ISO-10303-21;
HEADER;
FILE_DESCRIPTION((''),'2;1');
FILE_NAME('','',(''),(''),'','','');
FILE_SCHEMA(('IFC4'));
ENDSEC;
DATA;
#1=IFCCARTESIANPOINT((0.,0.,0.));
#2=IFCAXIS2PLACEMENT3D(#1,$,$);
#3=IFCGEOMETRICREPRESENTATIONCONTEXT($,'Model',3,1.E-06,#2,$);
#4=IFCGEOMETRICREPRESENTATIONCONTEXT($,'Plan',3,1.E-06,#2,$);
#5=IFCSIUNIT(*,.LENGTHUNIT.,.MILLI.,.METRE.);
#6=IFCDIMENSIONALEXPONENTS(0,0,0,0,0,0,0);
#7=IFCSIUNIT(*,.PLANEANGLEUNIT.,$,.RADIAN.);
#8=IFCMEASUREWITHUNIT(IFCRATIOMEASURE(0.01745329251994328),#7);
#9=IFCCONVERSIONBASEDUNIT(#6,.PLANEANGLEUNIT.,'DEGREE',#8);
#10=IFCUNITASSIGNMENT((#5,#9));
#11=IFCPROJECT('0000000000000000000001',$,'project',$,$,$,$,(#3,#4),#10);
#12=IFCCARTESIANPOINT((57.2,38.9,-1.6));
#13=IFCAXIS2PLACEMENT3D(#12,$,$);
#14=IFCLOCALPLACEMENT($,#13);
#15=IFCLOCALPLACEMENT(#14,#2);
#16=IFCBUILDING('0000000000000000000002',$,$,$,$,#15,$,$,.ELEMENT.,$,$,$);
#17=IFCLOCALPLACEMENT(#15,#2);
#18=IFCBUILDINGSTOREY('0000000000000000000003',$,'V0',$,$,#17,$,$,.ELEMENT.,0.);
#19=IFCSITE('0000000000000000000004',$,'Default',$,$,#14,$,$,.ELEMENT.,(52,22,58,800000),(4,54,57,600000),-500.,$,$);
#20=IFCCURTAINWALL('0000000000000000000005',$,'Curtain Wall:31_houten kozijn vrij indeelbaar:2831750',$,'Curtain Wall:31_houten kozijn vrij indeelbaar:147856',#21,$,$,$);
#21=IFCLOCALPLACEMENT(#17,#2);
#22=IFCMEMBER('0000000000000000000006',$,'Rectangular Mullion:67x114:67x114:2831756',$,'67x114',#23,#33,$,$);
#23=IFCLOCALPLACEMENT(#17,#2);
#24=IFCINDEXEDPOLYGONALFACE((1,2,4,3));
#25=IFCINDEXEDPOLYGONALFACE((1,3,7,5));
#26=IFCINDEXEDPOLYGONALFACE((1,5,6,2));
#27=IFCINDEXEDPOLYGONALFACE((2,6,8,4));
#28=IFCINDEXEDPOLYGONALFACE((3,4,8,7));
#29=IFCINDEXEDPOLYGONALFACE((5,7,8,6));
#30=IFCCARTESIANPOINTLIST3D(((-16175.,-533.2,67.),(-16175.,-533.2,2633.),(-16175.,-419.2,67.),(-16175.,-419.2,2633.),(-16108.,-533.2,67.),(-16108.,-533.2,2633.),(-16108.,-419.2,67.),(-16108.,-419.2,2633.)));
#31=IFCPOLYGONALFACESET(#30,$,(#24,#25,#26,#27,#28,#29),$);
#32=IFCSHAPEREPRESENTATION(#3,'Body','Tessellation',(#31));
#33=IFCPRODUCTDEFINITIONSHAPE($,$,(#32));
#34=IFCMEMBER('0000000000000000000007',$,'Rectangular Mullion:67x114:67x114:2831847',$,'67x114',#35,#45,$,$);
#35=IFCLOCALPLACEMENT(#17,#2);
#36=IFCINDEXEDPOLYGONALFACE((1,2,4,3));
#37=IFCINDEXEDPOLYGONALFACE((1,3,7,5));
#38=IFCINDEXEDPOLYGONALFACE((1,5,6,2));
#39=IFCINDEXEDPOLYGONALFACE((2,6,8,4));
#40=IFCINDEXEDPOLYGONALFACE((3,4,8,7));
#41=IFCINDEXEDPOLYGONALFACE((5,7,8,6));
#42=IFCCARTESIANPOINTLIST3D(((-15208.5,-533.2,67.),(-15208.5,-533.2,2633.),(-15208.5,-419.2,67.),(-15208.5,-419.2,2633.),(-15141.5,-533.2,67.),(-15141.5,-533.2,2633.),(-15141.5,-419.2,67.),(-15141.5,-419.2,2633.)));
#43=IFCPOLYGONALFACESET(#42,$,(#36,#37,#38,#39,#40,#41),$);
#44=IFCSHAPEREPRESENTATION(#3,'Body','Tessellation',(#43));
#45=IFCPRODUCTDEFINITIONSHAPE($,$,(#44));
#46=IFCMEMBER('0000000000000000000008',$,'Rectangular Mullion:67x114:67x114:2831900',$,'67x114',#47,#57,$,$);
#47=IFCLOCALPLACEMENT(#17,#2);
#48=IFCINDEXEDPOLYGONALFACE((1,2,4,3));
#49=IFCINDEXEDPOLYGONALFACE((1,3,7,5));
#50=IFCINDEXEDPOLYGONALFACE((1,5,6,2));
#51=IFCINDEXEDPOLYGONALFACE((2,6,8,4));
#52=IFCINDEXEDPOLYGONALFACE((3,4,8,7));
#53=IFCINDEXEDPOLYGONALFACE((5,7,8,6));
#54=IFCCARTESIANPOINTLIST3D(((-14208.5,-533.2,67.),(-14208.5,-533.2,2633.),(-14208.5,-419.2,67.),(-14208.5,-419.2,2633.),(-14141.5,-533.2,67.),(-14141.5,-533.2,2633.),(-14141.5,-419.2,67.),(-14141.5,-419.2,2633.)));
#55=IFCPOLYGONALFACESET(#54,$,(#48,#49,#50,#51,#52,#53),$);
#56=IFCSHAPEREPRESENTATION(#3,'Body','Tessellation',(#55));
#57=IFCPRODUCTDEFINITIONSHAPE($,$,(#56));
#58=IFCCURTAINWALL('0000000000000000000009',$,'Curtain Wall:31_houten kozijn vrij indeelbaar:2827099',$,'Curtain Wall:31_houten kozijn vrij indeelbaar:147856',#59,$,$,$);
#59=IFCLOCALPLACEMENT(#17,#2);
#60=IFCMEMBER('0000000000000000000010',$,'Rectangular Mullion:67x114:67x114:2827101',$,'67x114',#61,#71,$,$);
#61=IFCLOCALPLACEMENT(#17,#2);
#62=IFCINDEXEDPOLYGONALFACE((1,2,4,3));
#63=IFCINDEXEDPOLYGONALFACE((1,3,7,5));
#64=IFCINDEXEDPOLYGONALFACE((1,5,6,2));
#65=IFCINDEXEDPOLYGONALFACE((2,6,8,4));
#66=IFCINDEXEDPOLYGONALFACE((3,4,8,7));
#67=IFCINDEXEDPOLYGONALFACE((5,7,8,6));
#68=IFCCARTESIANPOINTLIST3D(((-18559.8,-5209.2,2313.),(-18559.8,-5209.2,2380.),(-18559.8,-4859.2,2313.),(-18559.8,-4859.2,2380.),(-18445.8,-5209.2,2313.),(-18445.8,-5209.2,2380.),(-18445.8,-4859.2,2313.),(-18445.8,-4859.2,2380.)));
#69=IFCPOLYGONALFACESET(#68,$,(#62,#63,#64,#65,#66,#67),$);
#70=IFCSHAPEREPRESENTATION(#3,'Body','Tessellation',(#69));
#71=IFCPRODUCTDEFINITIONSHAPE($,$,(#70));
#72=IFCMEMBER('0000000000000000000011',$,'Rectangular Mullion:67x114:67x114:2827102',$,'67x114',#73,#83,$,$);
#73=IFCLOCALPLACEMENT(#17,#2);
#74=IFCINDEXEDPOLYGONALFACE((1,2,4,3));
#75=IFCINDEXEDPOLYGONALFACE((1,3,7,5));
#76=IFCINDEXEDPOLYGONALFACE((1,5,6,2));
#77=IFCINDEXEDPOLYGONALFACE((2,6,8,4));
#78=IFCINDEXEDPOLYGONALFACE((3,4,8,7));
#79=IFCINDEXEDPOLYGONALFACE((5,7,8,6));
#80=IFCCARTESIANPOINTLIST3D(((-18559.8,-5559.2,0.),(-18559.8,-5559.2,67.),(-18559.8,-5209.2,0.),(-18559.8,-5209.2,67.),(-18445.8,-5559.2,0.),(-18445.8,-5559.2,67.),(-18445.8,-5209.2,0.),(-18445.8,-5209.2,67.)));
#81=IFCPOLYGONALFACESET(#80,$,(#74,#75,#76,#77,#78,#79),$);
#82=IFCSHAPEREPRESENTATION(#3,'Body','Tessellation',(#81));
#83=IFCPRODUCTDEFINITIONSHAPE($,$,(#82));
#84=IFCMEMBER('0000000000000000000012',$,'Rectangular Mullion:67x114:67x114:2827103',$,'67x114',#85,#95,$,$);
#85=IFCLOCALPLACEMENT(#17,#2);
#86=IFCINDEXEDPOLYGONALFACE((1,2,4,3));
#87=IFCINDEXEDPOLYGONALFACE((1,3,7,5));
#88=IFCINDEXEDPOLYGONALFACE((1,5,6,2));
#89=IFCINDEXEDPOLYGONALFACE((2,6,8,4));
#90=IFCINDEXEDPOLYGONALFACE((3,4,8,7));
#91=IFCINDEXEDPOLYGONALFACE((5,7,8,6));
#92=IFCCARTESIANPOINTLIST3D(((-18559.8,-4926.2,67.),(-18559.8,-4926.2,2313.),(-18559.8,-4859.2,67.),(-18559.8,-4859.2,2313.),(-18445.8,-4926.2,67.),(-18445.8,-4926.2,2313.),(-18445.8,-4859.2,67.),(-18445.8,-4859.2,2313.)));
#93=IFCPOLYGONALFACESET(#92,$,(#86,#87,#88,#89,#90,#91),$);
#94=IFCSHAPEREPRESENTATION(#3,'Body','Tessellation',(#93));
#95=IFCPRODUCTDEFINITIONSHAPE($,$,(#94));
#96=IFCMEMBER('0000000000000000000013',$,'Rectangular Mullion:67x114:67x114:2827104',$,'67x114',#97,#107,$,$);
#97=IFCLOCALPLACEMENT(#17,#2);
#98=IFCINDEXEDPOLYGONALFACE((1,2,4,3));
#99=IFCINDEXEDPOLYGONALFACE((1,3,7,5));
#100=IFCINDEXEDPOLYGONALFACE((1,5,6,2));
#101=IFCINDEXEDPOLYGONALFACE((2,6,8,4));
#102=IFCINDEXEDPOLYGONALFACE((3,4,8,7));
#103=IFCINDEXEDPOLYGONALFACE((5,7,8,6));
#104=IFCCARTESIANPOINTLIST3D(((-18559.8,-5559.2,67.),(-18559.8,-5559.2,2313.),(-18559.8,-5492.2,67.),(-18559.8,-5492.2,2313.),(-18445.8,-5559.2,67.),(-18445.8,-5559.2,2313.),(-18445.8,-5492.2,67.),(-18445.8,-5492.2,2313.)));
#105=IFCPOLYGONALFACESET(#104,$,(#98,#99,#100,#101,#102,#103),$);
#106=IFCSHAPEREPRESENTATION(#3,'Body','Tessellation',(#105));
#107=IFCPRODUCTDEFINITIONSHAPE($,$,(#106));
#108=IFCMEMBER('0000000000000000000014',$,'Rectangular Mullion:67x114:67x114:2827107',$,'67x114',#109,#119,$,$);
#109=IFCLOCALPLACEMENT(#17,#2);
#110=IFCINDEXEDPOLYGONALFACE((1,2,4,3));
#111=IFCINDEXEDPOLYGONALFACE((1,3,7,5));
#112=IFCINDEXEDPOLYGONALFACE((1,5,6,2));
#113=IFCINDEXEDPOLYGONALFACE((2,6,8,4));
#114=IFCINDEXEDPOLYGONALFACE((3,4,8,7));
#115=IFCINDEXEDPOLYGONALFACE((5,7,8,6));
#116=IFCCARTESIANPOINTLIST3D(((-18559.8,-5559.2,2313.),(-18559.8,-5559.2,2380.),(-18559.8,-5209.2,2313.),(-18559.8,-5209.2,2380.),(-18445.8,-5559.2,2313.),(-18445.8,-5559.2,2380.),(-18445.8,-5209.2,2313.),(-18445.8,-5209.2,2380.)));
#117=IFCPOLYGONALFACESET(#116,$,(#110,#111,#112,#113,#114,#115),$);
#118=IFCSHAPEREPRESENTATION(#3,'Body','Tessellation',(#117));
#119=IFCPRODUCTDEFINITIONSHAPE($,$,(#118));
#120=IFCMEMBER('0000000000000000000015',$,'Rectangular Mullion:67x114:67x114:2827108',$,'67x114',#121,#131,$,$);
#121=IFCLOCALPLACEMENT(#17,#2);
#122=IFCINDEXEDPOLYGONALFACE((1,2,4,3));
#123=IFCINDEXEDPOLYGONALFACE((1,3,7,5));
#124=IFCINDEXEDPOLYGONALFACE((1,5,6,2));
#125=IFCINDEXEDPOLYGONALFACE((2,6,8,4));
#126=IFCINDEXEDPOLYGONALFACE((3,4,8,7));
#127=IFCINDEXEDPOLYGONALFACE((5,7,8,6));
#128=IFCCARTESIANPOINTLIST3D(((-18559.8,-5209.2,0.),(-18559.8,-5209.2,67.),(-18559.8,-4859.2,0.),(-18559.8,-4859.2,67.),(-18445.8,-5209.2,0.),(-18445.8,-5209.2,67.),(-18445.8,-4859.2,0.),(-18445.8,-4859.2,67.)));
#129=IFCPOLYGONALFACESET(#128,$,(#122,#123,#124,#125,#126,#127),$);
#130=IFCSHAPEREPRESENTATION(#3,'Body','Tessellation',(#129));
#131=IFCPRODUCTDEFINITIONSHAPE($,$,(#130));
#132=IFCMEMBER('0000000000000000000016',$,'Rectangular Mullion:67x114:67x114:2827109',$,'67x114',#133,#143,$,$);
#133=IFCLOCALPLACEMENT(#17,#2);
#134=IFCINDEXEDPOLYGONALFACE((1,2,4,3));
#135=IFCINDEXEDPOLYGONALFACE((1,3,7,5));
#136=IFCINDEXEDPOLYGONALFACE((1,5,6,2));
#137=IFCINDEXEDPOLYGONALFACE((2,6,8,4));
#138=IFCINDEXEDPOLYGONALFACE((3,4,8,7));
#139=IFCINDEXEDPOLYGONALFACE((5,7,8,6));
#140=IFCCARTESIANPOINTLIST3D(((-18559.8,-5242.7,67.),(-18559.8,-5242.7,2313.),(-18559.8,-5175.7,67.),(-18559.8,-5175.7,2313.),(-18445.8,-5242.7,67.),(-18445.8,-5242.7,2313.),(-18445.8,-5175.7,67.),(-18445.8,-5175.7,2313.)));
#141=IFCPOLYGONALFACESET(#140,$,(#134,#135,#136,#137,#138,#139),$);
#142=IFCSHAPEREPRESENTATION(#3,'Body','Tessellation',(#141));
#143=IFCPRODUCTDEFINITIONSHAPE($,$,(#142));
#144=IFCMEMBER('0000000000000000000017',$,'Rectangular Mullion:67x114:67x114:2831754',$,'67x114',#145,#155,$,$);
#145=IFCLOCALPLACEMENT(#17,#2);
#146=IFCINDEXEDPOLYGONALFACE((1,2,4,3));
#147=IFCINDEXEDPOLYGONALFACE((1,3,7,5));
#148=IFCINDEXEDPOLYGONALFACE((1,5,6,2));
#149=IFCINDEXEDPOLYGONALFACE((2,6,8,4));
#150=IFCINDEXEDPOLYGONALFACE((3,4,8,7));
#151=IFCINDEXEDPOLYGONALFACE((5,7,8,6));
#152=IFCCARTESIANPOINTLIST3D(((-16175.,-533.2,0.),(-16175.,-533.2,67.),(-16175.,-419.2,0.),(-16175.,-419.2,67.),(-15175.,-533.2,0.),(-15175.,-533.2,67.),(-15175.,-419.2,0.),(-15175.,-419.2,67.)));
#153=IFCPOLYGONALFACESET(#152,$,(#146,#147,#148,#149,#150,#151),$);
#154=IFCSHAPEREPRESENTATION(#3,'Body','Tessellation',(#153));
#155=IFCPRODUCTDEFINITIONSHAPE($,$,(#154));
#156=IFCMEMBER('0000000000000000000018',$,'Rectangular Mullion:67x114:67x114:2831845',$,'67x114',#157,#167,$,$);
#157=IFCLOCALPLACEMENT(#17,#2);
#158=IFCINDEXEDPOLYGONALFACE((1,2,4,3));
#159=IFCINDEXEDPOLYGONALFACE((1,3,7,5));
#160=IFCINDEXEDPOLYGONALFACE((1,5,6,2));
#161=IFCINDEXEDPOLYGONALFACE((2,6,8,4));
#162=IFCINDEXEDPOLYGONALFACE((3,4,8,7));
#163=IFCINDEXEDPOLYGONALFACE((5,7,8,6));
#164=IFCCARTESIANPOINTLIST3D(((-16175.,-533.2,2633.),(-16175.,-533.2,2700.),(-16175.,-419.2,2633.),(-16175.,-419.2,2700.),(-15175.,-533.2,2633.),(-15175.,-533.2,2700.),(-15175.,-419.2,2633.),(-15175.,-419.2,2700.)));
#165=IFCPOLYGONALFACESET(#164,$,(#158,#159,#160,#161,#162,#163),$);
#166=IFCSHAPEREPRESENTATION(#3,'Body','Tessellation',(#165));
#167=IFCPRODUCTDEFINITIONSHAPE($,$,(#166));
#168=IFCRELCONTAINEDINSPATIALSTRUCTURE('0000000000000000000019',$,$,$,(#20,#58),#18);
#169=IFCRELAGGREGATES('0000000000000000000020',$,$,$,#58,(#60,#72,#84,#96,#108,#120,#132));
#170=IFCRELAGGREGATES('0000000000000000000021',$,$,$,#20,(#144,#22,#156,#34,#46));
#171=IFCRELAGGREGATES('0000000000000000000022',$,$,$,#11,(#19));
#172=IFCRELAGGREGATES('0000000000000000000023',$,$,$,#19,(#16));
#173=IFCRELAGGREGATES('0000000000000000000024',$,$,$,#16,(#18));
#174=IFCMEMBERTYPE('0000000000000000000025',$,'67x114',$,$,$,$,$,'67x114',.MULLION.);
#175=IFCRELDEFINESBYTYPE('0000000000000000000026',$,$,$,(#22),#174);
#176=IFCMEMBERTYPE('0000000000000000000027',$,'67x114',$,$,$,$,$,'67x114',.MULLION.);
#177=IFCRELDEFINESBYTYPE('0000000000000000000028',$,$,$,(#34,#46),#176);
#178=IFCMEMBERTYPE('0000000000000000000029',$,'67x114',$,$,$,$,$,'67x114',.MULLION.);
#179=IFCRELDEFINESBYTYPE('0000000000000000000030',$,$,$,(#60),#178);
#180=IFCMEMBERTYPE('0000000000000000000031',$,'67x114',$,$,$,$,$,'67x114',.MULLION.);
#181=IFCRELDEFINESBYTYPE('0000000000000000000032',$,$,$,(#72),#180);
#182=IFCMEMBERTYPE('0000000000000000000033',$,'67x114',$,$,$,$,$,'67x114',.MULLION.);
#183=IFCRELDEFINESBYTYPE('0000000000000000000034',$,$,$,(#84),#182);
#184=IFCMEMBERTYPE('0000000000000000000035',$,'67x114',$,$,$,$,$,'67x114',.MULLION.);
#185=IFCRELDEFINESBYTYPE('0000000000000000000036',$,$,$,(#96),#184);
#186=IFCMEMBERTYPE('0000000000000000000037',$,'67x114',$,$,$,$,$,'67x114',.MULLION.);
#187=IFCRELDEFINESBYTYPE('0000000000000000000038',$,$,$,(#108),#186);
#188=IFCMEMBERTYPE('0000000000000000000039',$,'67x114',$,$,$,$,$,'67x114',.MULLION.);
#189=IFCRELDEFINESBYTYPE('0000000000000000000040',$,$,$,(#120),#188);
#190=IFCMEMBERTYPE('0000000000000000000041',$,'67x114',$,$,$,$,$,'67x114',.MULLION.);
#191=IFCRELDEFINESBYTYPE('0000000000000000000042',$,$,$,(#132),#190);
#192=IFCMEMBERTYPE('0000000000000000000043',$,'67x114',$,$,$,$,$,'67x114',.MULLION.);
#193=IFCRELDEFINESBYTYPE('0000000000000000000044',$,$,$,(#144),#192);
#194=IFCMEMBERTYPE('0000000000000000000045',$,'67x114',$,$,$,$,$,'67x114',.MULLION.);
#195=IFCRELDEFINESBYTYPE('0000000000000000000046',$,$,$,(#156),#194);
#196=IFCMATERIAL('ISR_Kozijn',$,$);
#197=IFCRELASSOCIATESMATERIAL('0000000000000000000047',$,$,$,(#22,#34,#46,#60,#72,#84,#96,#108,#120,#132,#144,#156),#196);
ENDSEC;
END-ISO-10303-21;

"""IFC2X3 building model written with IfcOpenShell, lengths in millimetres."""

from ifc_helpers import new_model, entity, si_unit, converted_unit, frame, origin, origin_2d_with_axis, place, context, project, spatial, rectangle, extrude, source, transform, mapped, material, type_object, type_shapes, element, aggregate, save


model = new_model("IFC2X3")

# Units and contexts
model_context = context("Model", 3, precision=1e-06, world=origin())
plan_context = context("Plan", 3, precision=1e-06, world=origin())
ifc_project = project(units=[si_unit("LENGTHUNIT", "METRE", prefix="MILLI"), converted_unit("PLANEANGLEUNIT", "DEGREE", entity("IfcRatioMeasure", 0.01745329251994328), si_unit("PLANEANGLEUNIT", "RADIAN"), dimensions=[0, 0, 0, 0, 0, 0, 0])], contexts=[model_context, plan_context])

# Site, building, storey
site_placement = place(None, frame((57.2, 38.9, -1.6)))
site = spatial("IfcSite", under=ifc_project, at=site_placement, Name="Default", CompositionType="ELEMENT", RefLatitude=(52, 22, 58, 800000), RefLongitude=(4, 54, 57, 600000), RefElevation=-500.0)
building_placement = place(site_placement, origin())
building = spatial("IfcBuilding", under=site, at=building_placement, CompositionType="ELEMENT")
storey_placement = place(building_placement, origin())
storey = spatial("IfcBuildingStorey", under=building, at=storey_placement, Name="V0", CompositionType="ELEMENT", Elevation=0.0)

# Curtain walls, members
curtain_wall_1_placement = place(storey_placement, origin())
curtain_wall_1 = element("IfcCurtainWall", 1, at=curtain_wall_1_placement, inside=storey, Name="Curtain Wall:31_houten kozijn vrij indeelbaar:2831750", ObjectType="Curtain Wall:31_houten kozijn vrij indeelbaar:147856")
ifc_material_1 = material(Name="ISR_Kozijn")
member_type_1 = type_object("IfcMemberType", Name="67x114", ElementType="67x114", PredefinedType="MULLION")
shared_shape_1 = source(origin(), model_context, "Body", "SweptSolid", [
    extrude(rectangle(XDim=67.0, YDim=114.0, at=origin_2d_with_axis()), frame((-33.5, 57.0, -2566.0), z_axis=(0.0, 0.0, 1.0), x_axis=(-1.0, 0.0, 0.0)), (0.0, 0.0, 1.0), 2566.0),
])
type_shapes(member_type_1, [shared_shape_1])
placement_1 = place(building_placement, origin())
member_1_placement = place(placement_1, frame((-16175.0, -419.2, 2633.0), z_axis=(0.0, 0.0, 1.0), x_axis=(-1.0, 0.0, 0.0)))
member_1 = element("IfcMember", 2, at=member_1_placement, type_object=member_type_1, material=ifc_material_1, Name="Rectangular Mullion:67x114:67x114:2831756", ObjectType="67x114", context=model_context, shape_type="MappedRepresentation", body=[
    mapped(shared_shape_1, transform((0.0, 0.0, 0.0), scale=1.0)),
])
member_type_2 = type_object("IfcMemberType", Name="67x114", ElementType="67x114", PredefinedType="MULLION")
shared_shape_2 = source(origin(), model_context, "Body", "SweptSolid", [
    extrude(rectangle(XDim=67.0, YDim=114.0, at=origin_2d_with_axis()), frame((0.0, 57.0, -2566.0), z_axis=(0.0, 0.0, 1.0), x_axis=(-1.0, 0.0, 0.0)), (0.0, 0.0, 1.0), 2566.0),
])
type_shapes(member_type_2, [shared_shape_2])
member_2_placement = place(placement_1, frame((-15175.0, -419.2, 67.0), z_axis=(0.0, 0.0, -1.0), x_axis=(1.0, 0.0, 0.0)))
member_2 = element("IfcMember", 3, at=member_2_placement, type_object=member_type_2, material=ifc_material_1, Name="Rectangular Mullion:67x114:67x114:2831847", ObjectType="67x114", context=model_context, shape_type="MappedRepresentation", body=[
    mapped(shared_shape_2, transform((0.0, 0.0, 0.0), scale=1.0)),
])
member_3_placement = place(placement_1, frame((-14175.0, -419.2, 67.0), z_axis=(0.0, 0.0, -1.0), x_axis=(1.0, 0.0, 0.0)))
member_3 = element("IfcMember", 4, at=member_3_placement, type_object=member_type_2, material=ifc_material_1, Name="Rectangular Mullion:67x114:67x114:2831900", ObjectType="67x114", context=model_context, shape_type="MappedRepresentation", body=[
    mapped(shared_shape_2, transform((0.0, 0.0, 0.0), scale=1.0)),
])
curtain_wall_2_placement = place(storey_placement, origin())
curtain_wall_2 = element("IfcCurtainWall", 5, at=curtain_wall_2_placement, inside=storey, Name="Curtain Wall:31_houten kozijn vrij indeelbaar:2827099", ObjectType="Curtain Wall:31_houten kozijn vrij indeelbaar:147856")
member_type_3 = type_object("IfcMemberType", Name="67x114", ElementType="67x114", PredefinedType="MULLION")
shared_shape_3 = source(origin(), model_context, "Body", "SweptSolid", [
    extrude(rectangle(XDim=67.0, YDim=114.0, at=origin_2d_with_axis()), frame((-33.5, -57.0, -350.0), z_axis=(0.0, 0.0, 1.0), x_axis=(-1.0, 0.0, 0.0)), (0.0, 0.0, 1.0), 350.0),
])
type_shapes(member_type_3, [shared_shape_3])
placement_2 = place(building_placement, frame((0.0, 0.0, 625.0)))
member_4_placement = place(placement_2, frame((-18445.8, -4859.2, 1755.0), z_axis=(0.0, 1.0, 0.0), x_axis=(0.0, 0.0, 1.0)))
member_4 = element("IfcMember", 6, at=member_4_placement, type_object=member_type_3, material=ifc_material_1, Name="Rectangular Mullion:67x114:67x114:2827101", ObjectType="67x114", context=model_context, shape_type="MappedRepresentation", body=[
    mapped(shared_shape_3, transform((0.0, 0.0, 0.0), scale=1.0)),
])
member_type_4 = type_object("IfcMemberType", Name="67x114", ElementType="67x114", PredefinedType="MULLION")
shared_shape_4 = source(origin(), model_context, "Body", "SweptSolid", [
    extrude(rectangle(XDim=67.0, YDim=114.0, at=origin_2d_with_axis()), frame((-33.5, -57.0, -350.0), z_axis=(0.0, 0.0, 1.0), x_axis=(-1.0, 0.0, 0.0)), (0.0, 0.0, 1.0), 350.0),
])
type_shapes(member_type_4, [shared_shape_4])
member_5_placement = place(placement_1, frame((-18445.8, -5559.2, 0.0), z_axis=(0.0, -1.0, 0.0), x_axis=(0.0, 0.0, -1.0)))
member_5 = element("IfcMember", 7, at=member_5_placement, type_object=member_type_4, material=ifc_material_1, Name="Rectangular Mullion:67x114:67x114:2827102", ObjectType="67x114", context=model_context, shape_type="MappedRepresentation", body=[
    mapped(shared_shape_4, transform((0.0, 0.0, 0.0), scale=1.0)),
])
member_type_5 = type_object("IfcMemberType", Name="67x114", ElementType="67x114", PredefinedType="MULLION")
shared_shape_5 = source(origin(), model_context, "Body", "SweptSolid", [
    extrude(rectangle(XDim=67.0, YDim=114.0, at=origin_2d_with_axis()), frame((-33.5, -57.0, -2246.0), z_axis=(0.0, 0.0, 1.0), x_axis=(-1.0, 0.0, 0.0)), (0.0, 0.0, 1.0), 2246.0),
])
type_shapes(member_type_5, [shared_shape_5])
member_6_placement = place(placement_1, frame((-18445.8, -4859.2, 67.0), z_axis=(0.0, 0.0, -1.0), x_axis=(0.0, 1.0, 0.0)))
member_6 = element("IfcMember", 8, at=member_6_placement, type_object=member_type_5, material=ifc_material_1, Name="Rectangular Mullion:67x114:67x114:2827103", ObjectType="67x114", context=model_context, shape_type="MappedRepresentation", body=[
    mapped(shared_shape_5, transform((0.0, 0.0, 0.0), scale=1.0)),
])
member_type_6 = type_object("IfcMemberType", Name="67x114", ElementType="67x114", PredefinedType="MULLION")
shared_shape_6 = source(origin(), model_context, "Body", "SweptSolid", [
    extrude(rectangle(XDim=67.0, YDim=114.0, at=origin_2d_with_axis()), frame((-33.5, -57.0, -2246.0), z_axis=(0.0, 0.0, 1.0), x_axis=(-1.0, 0.0, 0.0)), (0.0, 0.0, 1.0), 2246.0),
])
type_shapes(member_type_6, [shared_shape_6])
member_7_placement = place(placement_1, frame((-18445.8, -5559.2, 2313.0), z_axis=(0.0, 0.0, 1.0), x_axis=(0.0, -1.0, 0.0)))
member_7 = element("IfcMember", 9, at=member_7_placement, type_object=member_type_6, material=ifc_material_1, Name="Rectangular Mullion:67x114:67x114:2827104", ObjectType="67x114", context=model_context, shape_type="MappedRepresentation", body=[
    mapped(shared_shape_6, transform((0.0, 0.0, 0.0), scale=1.0)),
])
member_type_7 = type_object("IfcMemberType", Name="67x114", ElementType="67x114", PredefinedType="MULLION")
shared_shape_7 = source(origin(), model_context, "Body", "SweptSolid", [
    extrude(rectangle(XDim=67.0, YDim=114.0, at=origin_2d_with_axis()), frame((-33.5, -57.0, -350.0), z_axis=(0.0, 0.0, 1.0), x_axis=(-1.0, 0.0, 0.0)), (0.0, 0.0, 1.0), 350.0),
])
type_shapes(member_type_7, [shared_shape_7])
member_8_placement = place(placement_2, frame((-18445.8, -5209.2, 1755.0), z_axis=(0.0, 1.0, 0.0), x_axis=(0.0, 0.0, 1.0)))
member_8 = element("IfcMember", 10, at=member_8_placement, type_object=member_type_7, material=ifc_material_1, Name="Rectangular Mullion:67x114:67x114:2827107", ObjectType="67x114", context=model_context, shape_type="MappedRepresentation", body=[
    mapped(shared_shape_7, transform((0.0, 0.0, 0.0), scale=1.0)),
])
member_type_8 = type_object("IfcMemberType", Name="67x114", ElementType="67x114", PredefinedType="MULLION")
shared_shape_8 = source(origin(), model_context, "Body", "SweptSolid", [
    extrude(rectangle(XDim=67.0, YDim=114.0, at=origin_2d_with_axis()), frame((-33.5, -57.0, -350.0), z_axis=(0.0, 0.0, 1.0), x_axis=(-1.0, 0.0, 0.0)), (0.0, 0.0, 1.0), 350.0),
])
type_shapes(member_type_8, [shared_shape_8])
member_9_placement = place(placement_1, frame((-18445.8, -5209.2, 0.0), z_axis=(0.0, -1.0, 0.0), x_axis=(0.0, 0.0, -1.0)))
member_9 = element("IfcMember", 11, at=member_9_placement, type_object=member_type_8, material=ifc_material_1, Name="Rectangular Mullion:67x114:67x114:2827108", ObjectType="67x114", context=model_context, shape_type="MappedRepresentation", body=[
    mapped(shared_shape_8, transform((0.0, 0.0, 0.0), scale=1.0)),
])
member_type_9 = type_object("IfcMemberType", Name="67x114", ElementType="67x114", PredefinedType="MULLION")
shared_shape_9 = source(origin(), model_context, "Body", "SweptSolid", [
    extrude(rectangle(XDim=67.0, YDim=114.0, at=origin_2d_with_axis()), frame((0.0, -57.0, -2246.0), z_axis=(0.0, 0.0, 1.0), x_axis=(-1.0, 0.0, 0.0)), (0.0, 0.0, 1.0), 2246.0),
])
type_shapes(member_type_9, [shared_shape_9])
member_10_placement = place(placement_1, frame((-18445.8, -5209.2, 67.0), z_axis=(0.0, 0.0, -1.0), x_axis=(0.0, 1.0, 0.0)))
member_10 = element("IfcMember", 12, at=member_10_placement, type_object=member_type_9, material=ifc_material_1, Name="Rectangular Mullion:67x114:67x114:2827109", ObjectType="67x114", context=model_context, shape_type="MappedRepresentation", body=[
    mapped(shared_shape_9, transform((0.0, 0.0, 0.0), scale=1.0)),
])

# Members
member_type_10 = type_object("IfcMemberType", Name="67x114", ElementType="67x114", PredefinedType="MULLION")
shared_shape_10 = source(origin(), model_context, "Body", "SweptSolid", [
    extrude(rectangle(XDim=67.0, YDim=114.0, at=origin_2d_with_axis()), frame((-33.5, 57.0, -1000.0), z_axis=(0.0, 0.0, 1.0), x_axis=(-1.0, 0.0, 0.0)), (0.0, 0.0, 1.0), 1000.0),
])
type_shapes(member_type_10, [shared_shape_10])
member_11_placement = place(placement_1, frame((-16175.0, -419.2, 0.0), z_axis=(-1.0, 0.0, 0.0), x_axis=(0.0, 0.0, -1.0)))
member_11 = element("IfcMember", 13, at=member_11_placement, type_object=member_type_10, material=ifc_material_1, Name="Rectangular Mullion:67x114:67x114:2831754", ObjectType="67x114", context=model_context, shape_type="MappedRepresentation", body=[
    mapped(shared_shape_10, transform((0.0, 0.0, 0.0), scale=1.0)),
])
member_type_11 = type_object("IfcMemberType", Name="67x114", ElementType="67x114", PredefinedType="MULLION")
shared_shape_11 = source(origin(), model_context, "Body", "SweptSolid", [
    extrude(rectangle(XDim=67.0, YDim=114.0, at=origin_2d_with_axis()), frame((-33.5, 57.0, -1000.0), z_axis=(0.0, 0.0, 1.0), x_axis=(-1.0, 0.0, 0.0)), (0.0, 0.0, 1.0), 1000.0),
])
type_shapes(member_type_11, [shared_shape_11])
placement_3 = place(building_placement, frame((0.0, 0.0, 2425.0)))
member_12_placement = place(placement_3, frame((-15175.0, -419.2, 275.0), z_axis=(1.0, 0.0, 0.0), x_axis=(0.0, 0.0, 1.0)))
member_12 = element("IfcMember", 14, at=member_12_placement, type_object=member_type_11, material=ifc_material_1, Name="Rectangular Mullion:67x114:67x114:2831845", ObjectType="67x114", context=model_context, shape_type="MappedRepresentation", body=[
    mapped(shared_shape_11, transform((0.0, 0.0, 0.0), scale=1.0)),
])

aggregate(curtain_wall_2, [member_4, member_5, member_6, member_7, member_8, member_9, member_10])
aggregate(curtain_wall_1, [member_11, member_1, member_12, member_2, member_3])

save(model, "model.ifc")
